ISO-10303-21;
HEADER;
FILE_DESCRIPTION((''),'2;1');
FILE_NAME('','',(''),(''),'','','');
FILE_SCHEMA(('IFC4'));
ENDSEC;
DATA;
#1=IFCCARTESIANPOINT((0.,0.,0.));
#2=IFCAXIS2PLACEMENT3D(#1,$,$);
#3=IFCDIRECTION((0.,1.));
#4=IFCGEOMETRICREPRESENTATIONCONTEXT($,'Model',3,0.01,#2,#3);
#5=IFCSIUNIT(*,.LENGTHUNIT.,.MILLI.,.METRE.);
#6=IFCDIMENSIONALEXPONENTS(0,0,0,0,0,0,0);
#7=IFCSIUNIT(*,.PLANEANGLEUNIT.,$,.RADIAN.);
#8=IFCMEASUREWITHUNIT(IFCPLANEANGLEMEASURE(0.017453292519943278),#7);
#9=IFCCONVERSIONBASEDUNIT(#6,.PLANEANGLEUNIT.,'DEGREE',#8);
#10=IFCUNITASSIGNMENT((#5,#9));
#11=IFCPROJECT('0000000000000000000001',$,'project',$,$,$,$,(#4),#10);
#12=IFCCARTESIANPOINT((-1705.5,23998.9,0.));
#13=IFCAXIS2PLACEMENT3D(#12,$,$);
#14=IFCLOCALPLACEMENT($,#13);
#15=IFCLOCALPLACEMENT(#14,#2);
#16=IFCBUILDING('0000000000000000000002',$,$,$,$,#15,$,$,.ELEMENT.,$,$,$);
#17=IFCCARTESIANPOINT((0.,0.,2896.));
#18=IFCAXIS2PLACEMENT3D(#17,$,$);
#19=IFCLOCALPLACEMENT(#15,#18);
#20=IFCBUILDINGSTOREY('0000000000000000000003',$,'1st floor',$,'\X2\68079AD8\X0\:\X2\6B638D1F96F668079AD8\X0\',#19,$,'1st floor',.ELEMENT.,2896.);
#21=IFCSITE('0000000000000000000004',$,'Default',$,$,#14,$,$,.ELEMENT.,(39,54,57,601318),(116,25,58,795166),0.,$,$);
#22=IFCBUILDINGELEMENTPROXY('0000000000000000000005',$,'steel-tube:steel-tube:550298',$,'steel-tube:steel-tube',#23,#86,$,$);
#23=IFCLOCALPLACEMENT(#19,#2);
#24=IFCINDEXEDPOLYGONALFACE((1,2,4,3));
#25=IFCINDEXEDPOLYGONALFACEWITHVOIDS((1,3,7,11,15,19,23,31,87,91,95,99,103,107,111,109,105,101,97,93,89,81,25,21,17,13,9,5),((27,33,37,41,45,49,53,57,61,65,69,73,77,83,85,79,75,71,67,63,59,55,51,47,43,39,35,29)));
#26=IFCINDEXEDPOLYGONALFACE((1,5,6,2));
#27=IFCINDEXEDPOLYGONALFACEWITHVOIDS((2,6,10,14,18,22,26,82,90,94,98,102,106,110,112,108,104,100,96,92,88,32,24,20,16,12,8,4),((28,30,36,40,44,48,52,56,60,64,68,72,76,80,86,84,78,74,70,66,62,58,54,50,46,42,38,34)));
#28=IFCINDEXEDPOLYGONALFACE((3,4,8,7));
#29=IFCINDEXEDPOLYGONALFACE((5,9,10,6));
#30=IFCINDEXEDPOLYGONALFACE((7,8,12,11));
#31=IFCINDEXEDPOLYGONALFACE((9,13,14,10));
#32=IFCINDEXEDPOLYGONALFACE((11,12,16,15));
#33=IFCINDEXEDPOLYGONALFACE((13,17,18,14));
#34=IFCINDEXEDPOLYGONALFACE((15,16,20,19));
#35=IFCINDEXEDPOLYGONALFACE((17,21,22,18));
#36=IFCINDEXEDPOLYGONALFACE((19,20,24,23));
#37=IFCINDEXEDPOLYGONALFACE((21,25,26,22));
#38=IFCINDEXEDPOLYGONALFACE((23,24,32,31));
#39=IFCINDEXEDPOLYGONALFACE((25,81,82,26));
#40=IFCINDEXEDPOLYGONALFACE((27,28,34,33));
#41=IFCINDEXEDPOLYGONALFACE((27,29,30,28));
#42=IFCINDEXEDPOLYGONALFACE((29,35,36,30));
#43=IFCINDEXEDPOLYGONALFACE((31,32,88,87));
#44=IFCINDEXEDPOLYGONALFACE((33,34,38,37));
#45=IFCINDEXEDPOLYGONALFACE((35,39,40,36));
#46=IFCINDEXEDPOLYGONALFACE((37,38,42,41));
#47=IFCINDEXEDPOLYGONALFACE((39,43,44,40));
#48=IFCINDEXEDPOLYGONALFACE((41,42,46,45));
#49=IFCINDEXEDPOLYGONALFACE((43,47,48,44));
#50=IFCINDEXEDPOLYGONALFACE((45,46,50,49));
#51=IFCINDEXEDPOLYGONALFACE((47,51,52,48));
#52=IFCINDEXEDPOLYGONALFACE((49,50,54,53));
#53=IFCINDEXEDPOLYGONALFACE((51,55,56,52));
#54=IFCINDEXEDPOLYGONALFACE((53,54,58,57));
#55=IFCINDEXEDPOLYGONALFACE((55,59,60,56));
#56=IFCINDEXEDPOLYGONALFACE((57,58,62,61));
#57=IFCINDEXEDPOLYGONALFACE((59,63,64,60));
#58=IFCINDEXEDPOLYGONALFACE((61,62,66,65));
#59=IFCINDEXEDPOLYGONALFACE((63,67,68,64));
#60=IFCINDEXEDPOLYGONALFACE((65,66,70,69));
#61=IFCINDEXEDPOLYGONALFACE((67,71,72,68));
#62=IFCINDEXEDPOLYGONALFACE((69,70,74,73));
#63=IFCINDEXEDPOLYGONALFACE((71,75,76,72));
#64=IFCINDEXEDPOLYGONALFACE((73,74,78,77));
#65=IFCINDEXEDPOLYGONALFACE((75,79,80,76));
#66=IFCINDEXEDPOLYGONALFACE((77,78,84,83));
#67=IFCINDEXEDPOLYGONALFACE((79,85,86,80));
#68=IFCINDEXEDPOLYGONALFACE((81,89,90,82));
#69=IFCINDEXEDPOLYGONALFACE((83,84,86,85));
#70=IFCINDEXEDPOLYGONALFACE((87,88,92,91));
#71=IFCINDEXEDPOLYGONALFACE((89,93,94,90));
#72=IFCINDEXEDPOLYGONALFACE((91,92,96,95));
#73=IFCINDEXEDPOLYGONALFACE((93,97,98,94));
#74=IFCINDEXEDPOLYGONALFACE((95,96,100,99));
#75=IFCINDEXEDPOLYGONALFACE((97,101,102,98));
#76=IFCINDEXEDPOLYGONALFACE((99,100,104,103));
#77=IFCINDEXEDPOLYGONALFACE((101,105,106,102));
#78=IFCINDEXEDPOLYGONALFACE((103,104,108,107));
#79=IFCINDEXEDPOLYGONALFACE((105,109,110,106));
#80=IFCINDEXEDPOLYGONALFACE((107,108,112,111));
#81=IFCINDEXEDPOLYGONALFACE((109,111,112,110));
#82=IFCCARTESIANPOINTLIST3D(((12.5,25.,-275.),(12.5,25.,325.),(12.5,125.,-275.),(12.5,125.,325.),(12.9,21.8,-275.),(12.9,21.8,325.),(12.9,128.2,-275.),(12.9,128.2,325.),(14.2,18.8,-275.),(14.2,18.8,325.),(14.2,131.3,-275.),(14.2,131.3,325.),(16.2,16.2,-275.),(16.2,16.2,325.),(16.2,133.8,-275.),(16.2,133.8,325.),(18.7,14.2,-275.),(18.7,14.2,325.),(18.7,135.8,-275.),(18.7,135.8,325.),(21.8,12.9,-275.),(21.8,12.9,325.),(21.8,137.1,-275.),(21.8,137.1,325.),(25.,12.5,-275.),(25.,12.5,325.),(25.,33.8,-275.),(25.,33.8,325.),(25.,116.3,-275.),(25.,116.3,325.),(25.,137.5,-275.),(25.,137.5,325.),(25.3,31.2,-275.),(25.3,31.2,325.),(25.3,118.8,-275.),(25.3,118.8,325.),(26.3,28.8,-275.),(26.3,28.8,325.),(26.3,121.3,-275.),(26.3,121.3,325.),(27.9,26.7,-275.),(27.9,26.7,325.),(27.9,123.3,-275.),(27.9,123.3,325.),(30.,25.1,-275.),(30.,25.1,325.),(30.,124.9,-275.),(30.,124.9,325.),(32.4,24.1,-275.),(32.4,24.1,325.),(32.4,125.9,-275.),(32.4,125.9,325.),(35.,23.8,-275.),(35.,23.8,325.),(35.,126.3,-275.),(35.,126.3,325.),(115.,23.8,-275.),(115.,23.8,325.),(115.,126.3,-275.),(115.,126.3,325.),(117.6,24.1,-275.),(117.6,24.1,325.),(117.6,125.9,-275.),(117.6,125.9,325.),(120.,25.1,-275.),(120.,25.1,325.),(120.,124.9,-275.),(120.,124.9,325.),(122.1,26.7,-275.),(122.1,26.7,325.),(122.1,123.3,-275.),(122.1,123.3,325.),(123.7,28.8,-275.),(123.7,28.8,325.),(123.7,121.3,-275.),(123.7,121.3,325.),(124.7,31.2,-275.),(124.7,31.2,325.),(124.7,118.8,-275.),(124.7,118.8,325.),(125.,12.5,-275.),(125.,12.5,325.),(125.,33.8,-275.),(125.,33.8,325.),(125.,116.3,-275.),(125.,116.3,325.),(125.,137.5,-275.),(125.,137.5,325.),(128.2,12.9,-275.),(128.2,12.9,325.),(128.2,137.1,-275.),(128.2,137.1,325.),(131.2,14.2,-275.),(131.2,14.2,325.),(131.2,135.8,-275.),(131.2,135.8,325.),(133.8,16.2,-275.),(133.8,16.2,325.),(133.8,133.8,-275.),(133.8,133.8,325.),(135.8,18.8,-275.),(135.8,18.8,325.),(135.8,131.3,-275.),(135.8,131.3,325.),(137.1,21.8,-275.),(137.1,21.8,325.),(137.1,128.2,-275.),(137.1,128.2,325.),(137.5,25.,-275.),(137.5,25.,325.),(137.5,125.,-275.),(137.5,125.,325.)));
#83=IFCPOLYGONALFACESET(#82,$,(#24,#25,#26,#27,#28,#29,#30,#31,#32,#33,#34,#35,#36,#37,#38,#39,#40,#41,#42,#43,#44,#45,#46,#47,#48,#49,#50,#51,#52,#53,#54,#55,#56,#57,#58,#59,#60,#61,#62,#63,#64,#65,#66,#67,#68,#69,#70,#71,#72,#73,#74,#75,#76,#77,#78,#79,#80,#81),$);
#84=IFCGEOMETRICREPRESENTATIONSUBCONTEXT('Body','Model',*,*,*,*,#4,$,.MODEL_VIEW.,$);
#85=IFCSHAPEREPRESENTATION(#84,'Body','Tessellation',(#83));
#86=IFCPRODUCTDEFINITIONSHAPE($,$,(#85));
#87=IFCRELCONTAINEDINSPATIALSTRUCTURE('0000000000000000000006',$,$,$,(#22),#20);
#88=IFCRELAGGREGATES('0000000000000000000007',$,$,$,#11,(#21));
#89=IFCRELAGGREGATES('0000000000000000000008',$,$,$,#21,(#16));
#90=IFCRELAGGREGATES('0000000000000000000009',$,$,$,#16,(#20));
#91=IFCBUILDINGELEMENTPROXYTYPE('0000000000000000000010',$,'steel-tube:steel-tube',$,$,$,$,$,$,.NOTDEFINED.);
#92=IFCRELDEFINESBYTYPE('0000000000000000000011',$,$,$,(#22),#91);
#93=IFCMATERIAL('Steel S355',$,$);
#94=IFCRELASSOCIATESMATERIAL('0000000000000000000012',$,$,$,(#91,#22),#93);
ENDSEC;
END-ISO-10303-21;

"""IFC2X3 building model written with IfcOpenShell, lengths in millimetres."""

from ifc_helpers import new_model, entity, si_unit, converted_unit, direction, frame, frame_2d, origin, place, context, subcontext, project, spatial, polyline, circle_curve, parameter, trimmed, segment, composite_curve, outline, extrude, source, transform, mapped, material, type_object, type_shapes, element, save


model = new_model("IFC2X3")

# Units and contexts
model_context = context("Model", 3, precision=0.01, world=origin(), true_north=direction((0.0, 1.0)))
body_context = subcontext(model_context, "Body", "Model", "MODEL_VIEW")
ifc_project = project(units=[si_unit("LENGTHUNIT", "METRE", prefix="MILLI"), converted_unit("PLANEANGLEUNIT", "DEGREE", entity("IfcPlaneAngleMeasure", 0.017453292519943278), si_unit("PLANEANGLEUNIT", "RADIAN"), dimensions=[0, 0, 0, 0, 0, 0, 0])], contexts=[model_context])

# Site, building, storey
site_placement = place(None, frame((-1705.5, 23998.9, 0.0)))
site = spatial("IfcSite", under=ifc_project, at=site_placement, Name="Default", CompositionType="ELEMENT", RefLatitude=(39, 54, 57, 601318), RefLongitude=(116, 25, 58, 795166), RefElevation=0.0)
building_placement = place(site_placement, origin())
building = spatial("IfcBuilding", under=site, at=building_placement, CompositionType="ELEMENT")
storey_placement = place(building_placement, frame((0.0, 0.0, 2896.0)))
storey = spatial("IfcBuildingStorey", under=building, at=storey_placement, Name="1st floor", ObjectType="标高:正负零标高", LongName="1st floor", CompositionType="ELEMENT", Elevation=2896.0)

# Shared definitions
ifc_material_1 = material(Name="Steel S355")

# Building element proxy
building_element_proxy_type = type_object("IfcBuildingElementProxyType", Name="steel-tube:steel-tube", PredefinedType="NOTDEFINED", material=ifc_material_1)
shared_shape_1 = source(origin(), body_context, "Body", "SweptSolid", [
    extrude(outline(composite_curve([segment(trimmed(circle_curve(frame_2d((50.0, -50.0), x_axis=(1.0, 0.0)), 12.5), [parameter(270.0)], [parameter(0.0)], True, "PARAMETER"), True, "CONTINUOUS"), segment(polyline([(62.5, -50.0), (62.5, 50.0)]), True, "CONTINUOUS"), segment(trimmed(circle_curve(frame_2d((50.0, 50.0), x_axis=(1.0, 0.0)), 12.5), [parameter(0.0)], [parameter(90.0)], True, "PARAMETER"), True, "CONTINUOUS"), segment(polyline([(50.0, 62.5), (-50.0, 62.5)]), True, "CONTINUOUS"), segment(trimmed(circle_curve(frame_2d((-50.0, 50.0), x_axis=(1.0, 0.0)), 12.5), [parameter(90.0)], [parameter(180.0)], True, "PARAMETER"), True, "CONTINUOUS"), segment(polyline([(-62.5, 50.0), (-62.5, -50.0)]), True, "CONTINUOUS"), segment(trimmed(circle_curve(frame_2d((-50.0, -50.0), x_axis=(1.0, 0.0)), 12.5), [parameter(180.0)], [parameter(270.0)], True, "PARAMETER"), True, "CONTINUOUS"), segment(polyline([(-50.0, -62.5), (50.0, -62.5)]), True, "CONTINUOUS")], self_intersect=False), holes=[composite_curve([segment(trimmed(circle_curve(frame_2d((-41.2, 40.0), x_axis=(1.0, 0.0)), 10.0), [parameter(90.0)], [parameter(180.0)], True, "PARAMETER"), False, "CONTINUOUS"), segment(polyline([(-41.3, 50.0), (41.2, 50.0)]), True, "CONTINUOUS"), segment(trimmed(circle_curve(frame_2d((41.2, 40.0), x_axis=(1.0, 0.0)), 10.0), [parameter(0.0)], [parameter(90.0)], True, "PARAMETER"), False, "CONTINUOUS"), segment(polyline([(51.2, 40.0), (51.2, -40.0)]), True, "CONTINUOUS"), segment(trimmed(circle_curve(frame_2d((41.2, -40.0), x_axis=(1.0, 0.0)), 10.0), [parameter(270.0)], [parameter(360.0)], True, "PARAMETER"), False, "CONTINUOUS"), segment(polyline([(41.2, -50.0), (-41.3, -50.0)]), True, "CONTINUOUS"), segment(trimmed(circle_curve(frame_2d((-41.3, -40.0), x_axis=(1.0, 0.0)), 10.0), [parameter(180.0)], [parameter(270.0)], True, "PARAMETER"), False, "CONTINUOUS"), segment(polyline([(-51.3, -40.0), (-51.3, 40.0)]), True, "CONTINUOUS")], self_intersect=False)]), frame((62.5, 62.5, -175.0)), (0.0, 0.0, 1.0), 600.0),
])
type_shapes(building_element_proxy_type, [shared_shape_1])
for number, where, z_axis, x_axis, name in (
    (1, (12.5, 137.5, -100.0), (0.0, 0.0, 1.0), (0.0, -1.0, 0.0), "steel-tube:steel-tube:550298"),
):
    element("IfcBuildingElementProxy", number, at=place(storey_placement, frame(where, z_axis=z_axis, x_axis=x_axis)), inside=storey, type_object=building_element_proxy_type, material=ifc_material_1, Name=name, ObjectType="steel-tube:steel-tube", context=body_context, shape_type="MappedRepresentation", body=[
        mapped(shared_shape_1, transform((0.0, 0.0, 0.0), scale=1.0)),
    ])

save(model, "model.ifc")
